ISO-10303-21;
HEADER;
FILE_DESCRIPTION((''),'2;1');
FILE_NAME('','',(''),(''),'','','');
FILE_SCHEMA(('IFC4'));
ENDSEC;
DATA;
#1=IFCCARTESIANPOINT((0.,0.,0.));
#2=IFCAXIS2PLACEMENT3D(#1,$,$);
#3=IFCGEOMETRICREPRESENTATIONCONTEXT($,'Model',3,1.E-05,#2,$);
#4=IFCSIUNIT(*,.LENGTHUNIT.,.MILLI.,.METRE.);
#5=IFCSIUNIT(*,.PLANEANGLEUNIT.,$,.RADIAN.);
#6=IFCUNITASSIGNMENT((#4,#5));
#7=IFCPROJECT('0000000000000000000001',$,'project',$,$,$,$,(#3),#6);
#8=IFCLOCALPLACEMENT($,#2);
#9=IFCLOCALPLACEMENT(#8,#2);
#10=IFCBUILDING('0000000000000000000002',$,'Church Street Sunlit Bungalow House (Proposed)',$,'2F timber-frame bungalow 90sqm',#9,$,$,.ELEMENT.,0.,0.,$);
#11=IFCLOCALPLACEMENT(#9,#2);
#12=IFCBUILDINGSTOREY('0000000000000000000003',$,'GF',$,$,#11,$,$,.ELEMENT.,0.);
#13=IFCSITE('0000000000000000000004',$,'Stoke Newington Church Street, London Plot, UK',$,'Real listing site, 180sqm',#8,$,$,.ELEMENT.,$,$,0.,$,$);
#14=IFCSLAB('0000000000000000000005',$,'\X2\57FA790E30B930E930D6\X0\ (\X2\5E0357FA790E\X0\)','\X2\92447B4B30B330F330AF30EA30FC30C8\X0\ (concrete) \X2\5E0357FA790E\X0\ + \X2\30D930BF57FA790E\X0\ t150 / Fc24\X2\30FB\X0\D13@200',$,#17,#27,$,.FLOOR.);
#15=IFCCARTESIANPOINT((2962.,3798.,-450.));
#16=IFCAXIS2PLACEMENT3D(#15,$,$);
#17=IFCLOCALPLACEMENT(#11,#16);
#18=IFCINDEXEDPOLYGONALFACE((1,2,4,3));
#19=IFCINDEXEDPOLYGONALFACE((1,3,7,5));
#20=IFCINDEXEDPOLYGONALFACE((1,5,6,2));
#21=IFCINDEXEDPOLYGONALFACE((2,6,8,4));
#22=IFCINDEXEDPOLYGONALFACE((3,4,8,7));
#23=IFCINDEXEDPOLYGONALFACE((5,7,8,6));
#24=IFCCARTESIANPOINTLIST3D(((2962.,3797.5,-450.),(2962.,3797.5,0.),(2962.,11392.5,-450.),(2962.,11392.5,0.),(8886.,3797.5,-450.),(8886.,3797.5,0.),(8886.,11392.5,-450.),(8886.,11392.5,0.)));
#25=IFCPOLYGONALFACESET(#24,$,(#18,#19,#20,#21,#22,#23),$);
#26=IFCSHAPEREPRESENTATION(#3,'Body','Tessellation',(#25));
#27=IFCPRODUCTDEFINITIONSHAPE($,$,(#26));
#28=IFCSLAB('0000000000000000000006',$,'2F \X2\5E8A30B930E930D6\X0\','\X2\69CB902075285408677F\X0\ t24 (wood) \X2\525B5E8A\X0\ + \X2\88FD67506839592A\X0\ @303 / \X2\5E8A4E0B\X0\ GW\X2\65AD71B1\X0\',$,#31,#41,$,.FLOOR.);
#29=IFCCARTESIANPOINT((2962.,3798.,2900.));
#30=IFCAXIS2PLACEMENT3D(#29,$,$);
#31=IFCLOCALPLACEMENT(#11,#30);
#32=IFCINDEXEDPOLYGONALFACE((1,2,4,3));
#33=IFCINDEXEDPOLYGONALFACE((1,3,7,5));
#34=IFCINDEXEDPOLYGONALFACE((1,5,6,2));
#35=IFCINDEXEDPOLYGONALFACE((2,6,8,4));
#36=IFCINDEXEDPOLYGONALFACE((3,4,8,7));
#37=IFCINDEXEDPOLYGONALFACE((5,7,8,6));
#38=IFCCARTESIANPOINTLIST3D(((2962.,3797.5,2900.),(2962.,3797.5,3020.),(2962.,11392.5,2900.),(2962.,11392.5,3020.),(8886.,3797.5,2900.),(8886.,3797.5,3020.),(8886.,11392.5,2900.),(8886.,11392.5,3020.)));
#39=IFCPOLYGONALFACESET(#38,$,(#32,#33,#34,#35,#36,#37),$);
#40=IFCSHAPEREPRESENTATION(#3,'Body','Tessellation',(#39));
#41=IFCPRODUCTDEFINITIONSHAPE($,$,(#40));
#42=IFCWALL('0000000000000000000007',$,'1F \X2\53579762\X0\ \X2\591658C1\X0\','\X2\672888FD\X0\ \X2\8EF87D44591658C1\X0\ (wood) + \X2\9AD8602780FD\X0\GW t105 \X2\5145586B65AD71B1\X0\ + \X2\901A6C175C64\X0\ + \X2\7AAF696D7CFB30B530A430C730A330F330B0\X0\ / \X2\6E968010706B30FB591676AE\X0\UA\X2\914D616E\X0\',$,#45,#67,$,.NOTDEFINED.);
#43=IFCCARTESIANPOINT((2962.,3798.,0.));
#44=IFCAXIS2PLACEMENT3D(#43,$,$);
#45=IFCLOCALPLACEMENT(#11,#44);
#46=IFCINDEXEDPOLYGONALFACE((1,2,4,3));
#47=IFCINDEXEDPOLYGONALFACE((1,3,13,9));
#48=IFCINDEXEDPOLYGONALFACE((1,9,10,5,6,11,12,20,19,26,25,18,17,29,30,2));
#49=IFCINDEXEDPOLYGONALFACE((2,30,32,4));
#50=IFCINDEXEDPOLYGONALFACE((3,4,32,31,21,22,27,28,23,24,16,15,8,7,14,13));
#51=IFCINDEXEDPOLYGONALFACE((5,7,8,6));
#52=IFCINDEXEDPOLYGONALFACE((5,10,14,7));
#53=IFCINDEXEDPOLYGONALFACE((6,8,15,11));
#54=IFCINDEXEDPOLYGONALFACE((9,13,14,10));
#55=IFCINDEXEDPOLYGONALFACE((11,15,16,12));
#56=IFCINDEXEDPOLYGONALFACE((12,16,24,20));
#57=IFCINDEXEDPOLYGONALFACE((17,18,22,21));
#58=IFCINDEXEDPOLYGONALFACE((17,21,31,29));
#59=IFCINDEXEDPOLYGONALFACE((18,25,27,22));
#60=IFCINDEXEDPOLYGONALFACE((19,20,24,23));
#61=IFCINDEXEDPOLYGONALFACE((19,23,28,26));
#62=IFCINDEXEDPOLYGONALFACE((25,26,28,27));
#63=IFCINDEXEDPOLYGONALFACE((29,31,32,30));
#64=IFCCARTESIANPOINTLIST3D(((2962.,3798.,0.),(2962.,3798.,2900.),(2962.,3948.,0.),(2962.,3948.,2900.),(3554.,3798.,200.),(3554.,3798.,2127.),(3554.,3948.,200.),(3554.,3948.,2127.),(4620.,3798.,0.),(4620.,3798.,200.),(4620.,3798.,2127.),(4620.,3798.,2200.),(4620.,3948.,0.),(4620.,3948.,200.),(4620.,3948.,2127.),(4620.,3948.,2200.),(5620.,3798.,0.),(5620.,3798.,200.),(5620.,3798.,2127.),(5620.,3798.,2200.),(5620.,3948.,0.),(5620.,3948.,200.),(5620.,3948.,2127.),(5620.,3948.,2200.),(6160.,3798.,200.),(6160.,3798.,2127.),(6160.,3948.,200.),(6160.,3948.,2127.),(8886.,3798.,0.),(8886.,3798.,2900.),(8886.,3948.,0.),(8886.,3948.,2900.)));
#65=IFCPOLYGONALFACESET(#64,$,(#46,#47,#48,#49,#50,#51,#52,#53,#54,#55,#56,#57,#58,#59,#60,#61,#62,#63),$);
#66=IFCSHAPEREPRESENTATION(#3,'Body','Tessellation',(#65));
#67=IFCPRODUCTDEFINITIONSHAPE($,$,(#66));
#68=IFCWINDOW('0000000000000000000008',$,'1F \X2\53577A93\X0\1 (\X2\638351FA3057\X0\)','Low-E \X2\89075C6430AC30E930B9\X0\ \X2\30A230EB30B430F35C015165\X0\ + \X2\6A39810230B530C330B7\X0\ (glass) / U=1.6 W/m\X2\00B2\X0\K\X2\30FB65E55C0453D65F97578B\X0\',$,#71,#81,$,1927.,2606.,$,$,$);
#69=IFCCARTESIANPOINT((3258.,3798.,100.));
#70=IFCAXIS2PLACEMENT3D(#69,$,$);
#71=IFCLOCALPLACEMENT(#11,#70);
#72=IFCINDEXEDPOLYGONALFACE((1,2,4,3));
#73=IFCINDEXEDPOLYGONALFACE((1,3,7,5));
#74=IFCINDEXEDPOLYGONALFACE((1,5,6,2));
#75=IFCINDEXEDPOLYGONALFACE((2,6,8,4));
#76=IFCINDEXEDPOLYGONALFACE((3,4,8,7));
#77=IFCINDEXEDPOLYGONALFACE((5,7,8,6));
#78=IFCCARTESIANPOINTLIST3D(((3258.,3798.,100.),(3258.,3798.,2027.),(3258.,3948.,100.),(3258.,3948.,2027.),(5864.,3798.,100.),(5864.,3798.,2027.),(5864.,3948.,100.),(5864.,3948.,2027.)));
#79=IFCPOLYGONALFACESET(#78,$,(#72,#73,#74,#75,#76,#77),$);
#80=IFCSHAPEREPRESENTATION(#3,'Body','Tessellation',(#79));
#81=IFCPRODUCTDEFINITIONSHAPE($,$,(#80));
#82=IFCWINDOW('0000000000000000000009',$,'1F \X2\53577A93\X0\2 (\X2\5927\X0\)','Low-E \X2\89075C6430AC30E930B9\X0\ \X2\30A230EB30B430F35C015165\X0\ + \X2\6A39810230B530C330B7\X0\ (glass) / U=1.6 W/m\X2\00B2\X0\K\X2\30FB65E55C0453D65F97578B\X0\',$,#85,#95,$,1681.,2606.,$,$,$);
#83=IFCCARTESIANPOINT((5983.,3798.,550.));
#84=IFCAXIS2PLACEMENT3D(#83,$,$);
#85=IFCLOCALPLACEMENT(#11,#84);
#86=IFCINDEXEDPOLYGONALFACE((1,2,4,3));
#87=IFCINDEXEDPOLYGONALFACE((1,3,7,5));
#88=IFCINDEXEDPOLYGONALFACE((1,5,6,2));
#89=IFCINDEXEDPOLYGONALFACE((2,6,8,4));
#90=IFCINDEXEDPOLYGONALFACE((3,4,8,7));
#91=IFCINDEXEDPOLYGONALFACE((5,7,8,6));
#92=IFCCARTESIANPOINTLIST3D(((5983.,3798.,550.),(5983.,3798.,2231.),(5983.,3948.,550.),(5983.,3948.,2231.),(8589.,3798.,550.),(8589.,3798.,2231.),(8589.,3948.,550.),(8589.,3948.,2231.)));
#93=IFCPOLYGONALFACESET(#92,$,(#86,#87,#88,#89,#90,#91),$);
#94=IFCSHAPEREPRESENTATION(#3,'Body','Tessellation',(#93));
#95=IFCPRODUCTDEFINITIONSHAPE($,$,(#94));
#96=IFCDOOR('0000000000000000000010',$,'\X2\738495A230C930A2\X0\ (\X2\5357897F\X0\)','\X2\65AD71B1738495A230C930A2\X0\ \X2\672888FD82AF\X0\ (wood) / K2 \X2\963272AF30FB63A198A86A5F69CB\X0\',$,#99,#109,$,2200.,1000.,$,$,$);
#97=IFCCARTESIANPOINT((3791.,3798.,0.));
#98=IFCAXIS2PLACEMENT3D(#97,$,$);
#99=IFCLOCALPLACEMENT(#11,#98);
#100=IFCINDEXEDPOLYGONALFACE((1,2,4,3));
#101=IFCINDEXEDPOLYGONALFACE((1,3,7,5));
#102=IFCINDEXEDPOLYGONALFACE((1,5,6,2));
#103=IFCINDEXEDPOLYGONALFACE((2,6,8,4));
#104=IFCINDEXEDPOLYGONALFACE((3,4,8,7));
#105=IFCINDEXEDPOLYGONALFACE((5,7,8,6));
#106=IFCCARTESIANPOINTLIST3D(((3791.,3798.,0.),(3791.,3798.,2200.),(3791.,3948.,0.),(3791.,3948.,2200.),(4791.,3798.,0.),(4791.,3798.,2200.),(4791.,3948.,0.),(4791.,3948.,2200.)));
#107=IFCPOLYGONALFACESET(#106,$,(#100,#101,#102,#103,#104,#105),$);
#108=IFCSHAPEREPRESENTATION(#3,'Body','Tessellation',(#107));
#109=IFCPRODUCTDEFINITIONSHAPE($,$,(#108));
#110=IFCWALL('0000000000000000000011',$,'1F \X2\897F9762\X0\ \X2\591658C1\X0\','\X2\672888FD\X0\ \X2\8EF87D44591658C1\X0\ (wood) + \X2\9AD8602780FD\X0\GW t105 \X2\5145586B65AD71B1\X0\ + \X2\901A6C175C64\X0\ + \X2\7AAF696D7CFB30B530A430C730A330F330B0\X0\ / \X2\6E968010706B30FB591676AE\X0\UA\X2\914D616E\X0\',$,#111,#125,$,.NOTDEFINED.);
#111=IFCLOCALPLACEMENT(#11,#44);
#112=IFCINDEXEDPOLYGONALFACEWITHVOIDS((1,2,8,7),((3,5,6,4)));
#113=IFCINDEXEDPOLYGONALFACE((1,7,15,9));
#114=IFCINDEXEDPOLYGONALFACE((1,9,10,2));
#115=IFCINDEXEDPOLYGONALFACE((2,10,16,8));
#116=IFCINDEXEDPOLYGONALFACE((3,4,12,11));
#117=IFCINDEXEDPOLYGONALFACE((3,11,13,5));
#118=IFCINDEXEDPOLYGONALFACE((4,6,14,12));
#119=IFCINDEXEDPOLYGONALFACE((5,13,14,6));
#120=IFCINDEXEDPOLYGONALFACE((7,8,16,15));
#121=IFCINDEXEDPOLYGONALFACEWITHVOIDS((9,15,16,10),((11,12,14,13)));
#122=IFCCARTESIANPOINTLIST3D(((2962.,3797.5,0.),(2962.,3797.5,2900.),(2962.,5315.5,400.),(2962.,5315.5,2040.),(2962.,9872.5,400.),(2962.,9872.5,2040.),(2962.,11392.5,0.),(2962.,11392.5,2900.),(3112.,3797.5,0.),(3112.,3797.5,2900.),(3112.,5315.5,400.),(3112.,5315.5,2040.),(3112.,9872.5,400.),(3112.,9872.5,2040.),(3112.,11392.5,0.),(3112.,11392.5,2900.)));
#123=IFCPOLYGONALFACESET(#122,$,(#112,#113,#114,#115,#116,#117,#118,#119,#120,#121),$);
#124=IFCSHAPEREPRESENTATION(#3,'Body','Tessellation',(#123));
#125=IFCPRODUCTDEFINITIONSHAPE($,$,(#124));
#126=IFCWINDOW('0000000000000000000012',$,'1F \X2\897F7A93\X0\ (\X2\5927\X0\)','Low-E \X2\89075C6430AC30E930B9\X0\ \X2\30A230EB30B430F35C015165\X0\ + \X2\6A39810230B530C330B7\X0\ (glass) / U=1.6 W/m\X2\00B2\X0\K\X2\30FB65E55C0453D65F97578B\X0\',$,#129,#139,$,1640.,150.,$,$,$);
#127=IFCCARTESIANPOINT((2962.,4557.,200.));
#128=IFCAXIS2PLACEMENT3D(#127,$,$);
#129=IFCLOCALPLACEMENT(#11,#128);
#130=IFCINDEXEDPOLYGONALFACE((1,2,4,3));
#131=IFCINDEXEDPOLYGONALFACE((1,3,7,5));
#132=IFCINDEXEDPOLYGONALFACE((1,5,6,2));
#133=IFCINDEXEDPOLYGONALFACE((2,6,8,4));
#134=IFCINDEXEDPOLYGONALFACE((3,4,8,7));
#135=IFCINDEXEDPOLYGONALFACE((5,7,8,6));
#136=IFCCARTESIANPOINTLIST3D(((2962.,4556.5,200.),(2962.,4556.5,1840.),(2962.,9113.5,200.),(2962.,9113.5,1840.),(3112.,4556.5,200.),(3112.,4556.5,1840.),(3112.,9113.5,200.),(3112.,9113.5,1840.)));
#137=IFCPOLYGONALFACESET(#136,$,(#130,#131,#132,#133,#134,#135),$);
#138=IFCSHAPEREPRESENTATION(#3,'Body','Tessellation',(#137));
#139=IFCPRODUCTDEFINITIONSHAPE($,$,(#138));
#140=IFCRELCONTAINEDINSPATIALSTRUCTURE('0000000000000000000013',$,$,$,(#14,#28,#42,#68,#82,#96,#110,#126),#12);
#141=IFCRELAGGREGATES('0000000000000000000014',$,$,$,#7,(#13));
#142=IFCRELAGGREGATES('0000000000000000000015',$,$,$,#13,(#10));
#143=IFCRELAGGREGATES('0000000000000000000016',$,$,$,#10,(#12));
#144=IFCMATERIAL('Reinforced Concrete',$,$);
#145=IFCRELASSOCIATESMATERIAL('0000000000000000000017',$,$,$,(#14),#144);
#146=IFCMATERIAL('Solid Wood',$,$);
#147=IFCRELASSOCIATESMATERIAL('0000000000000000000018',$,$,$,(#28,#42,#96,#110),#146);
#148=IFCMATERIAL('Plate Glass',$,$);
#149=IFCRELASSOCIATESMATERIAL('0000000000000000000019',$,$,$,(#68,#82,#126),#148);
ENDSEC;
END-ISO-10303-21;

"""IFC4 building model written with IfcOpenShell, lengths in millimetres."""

from ifc_helpers import new_model, si_unit, frame, frame_2d, origin, place, context, project, spatial, rectangle, extrude, material, element, fill, save


model = new_model("IFC4")

# Units and contexts
model_context = context("Model", 3, precision=1e-05, world=origin())
ifc_project = project(units=[si_unit("LENGTHUNIT", "METRE", prefix="MILLI"), si_unit("PLANEANGLEUNIT", "RADIAN")], contexts=[model_context])

# Site, building, storey
site_placement = place(None, origin())
site = spatial("IfcSite", under=ifc_project, at=site_placement, Name="Stoke Newington Church Street, London Plot, UK", ObjectType="Real listing site, 180sqm", CompositionType="ELEMENT", RefElevation=0.0)
building_placement = place(site_placement, origin())
building = spatial("IfcBuilding", under=site, at=building_placement, Name="Church Street Sunlit Bungalow House (Proposed)", ObjectType="2F timber-frame bungalow 90sqm", CompositionType="ELEMENT", ElevationOfRefHeight=0.0, ElevationOfTerrain=0.0)
storey_placement = place(building_placement, origin())
storey = spatial("IfcBuildingStorey", under=building, at=storey_placement, Name="GF", CompositionType="ELEMENT", Elevation=0.0)

# Slabs
ifc_material_1 = material(Name="Reinforced Concrete")
slab_1_placement = place(storey_placement, frame((2962.0, 3798.0, -450.0)))
element("IfcSlab", 1, at=slab_1_placement, inside=storey, material=ifc_material_1, Name="基礎スラブ (布基礎)", Description="鉄筋コンクリート (concrete) 布基礎 + ベタ基礎 t150 / Fc24・D13@200", PredefinedType="FLOOR", context=model_context, shape_type="SweptSolid", body=[
    extrude(rectangle(XDim=5924.0, YDim=7595.0, at=frame_2d((2962.0, 3797.0))), frame((2962.0, 3798.0, -450.0)), (0.0, 0.0, 1.0), 450.0),
])
ifc_material_2 = material(Name="Solid Wood")
slab_2_placement = place(storey_placement, frame((2962.0, 3798.0, 2900.0)))
element("IfcSlab", 2, at=slab_2_placement, inside=storey, material=ifc_material_2, Name="2F 床スラブ", Description="構造用合板 t24 (wood) 剛床 + 製材根太 @303 / 床下 GW断熱", PredefinedType="FLOOR", context=model_context, shape_type="SweptSolid", body=[
    extrude(rectangle(XDim=5924.0, YDim=7595.0, at=frame_2d((2962.0, 3797.0))), frame((2962.0, 3798.0, 2900.0)), (0.0, 0.0, 1.0), 120.0),
])

# Wall, openings, windows, door
wall_1_placement = place(storey_placement, frame((2962.0, 3798.0, 0.0)))
wall_1 = element("IfcWall", 3, at=wall_1_placement, inside=storey, material=ifc_material_2, Name="1F 南面 外壁", Description="木製 軸組外壁 (wood) + 高性能GW t105 充填断熱 + 通気層 + 窯業系サイディング / 準耐火・外皮UA配慮", PredefinedType="NOTDEFINED", context=model_context, shape_type="SweptSolid", body=[
    extrude(rectangle(XDim=5924.0, YDim=150.0, at=frame_2d((2962.0, 75.0))), frame((2962.0, 3798.0, 0.0)), (0.0, 0.0, 1.0), 2900.0),
])
opening_1_placement = place(storey_placement, frame((3258.0, 3798.0, 100.0)))
opening_1 = element("IfcOpeningElement", 4, at=opening_1_placement, cuts=wall_1, PredefinedType="NOTDEFINED", context=model_context, shape_type="SweptSolid", body=[
    extrude(rectangle(XDim=2606.0, YDim=150.0, at=frame_2d((1303.0, 75.0))), frame((3258.0, 3798.0, 100.0)), (0.0, 0.0, 1.0), 1927.0),
])
opening_2_placement = place(storey_placement, frame((5983.0, 3798.0, 550.0)))
opening_2 = element("IfcOpeningElement", 5, at=opening_2_placement, cuts=wall_1, PredefinedType="NOTDEFINED", context=model_context, shape_type="SweptSolid", body=[
    extrude(rectangle(XDim=2606.0, YDim=150.0, at=frame_2d((1303.0, 75.0))), frame((5983.0, 3798.0, 550.0)), (0.0, 0.0, 1.0), 1681.0),
])
opening_3_placement = place(storey_placement, frame((3791.0, 3798.0, 0.0)))
opening_3 = element("IfcOpeningElement", 6, at=opening_3_placement, cuts=wall_1, PredefinedType="NOTDEFINED", context=model_context, shape_type="SweptSolid", body=[
    extrude(rectangle(XDim=1000.0, YDim=150.0, at=frame_2d((500.0, 75.0))), frame((3791.0, 3798.0, 0.0)), (0.0, 0.0, 1.0), 2200.0),
])
ifc_material_3 = material(Name="Plate Glass")
window_1_placement = place(storey_placement, frame((3258.0, 3798.0, 100.0)))
window_1 = element("IfcWindow", 7, at=window_1_placement, inside=storey, material=ifc_material_3, Name="1F 南窓1 (掃出し)", Description="Low-E 複層ガラス アルゴン封入 + 樹脂サッシ (glass) / U=1.6 W/m²K・日射取得型", OverallHeight=1927.0, OverallWidth=2606.0, context=model_context, shape_type="SweptSolid", body=[
    extrude(rectangle(XDim=2606.0, YDim=150.0, at=frame_2d((1303.0, 75.0))), frame((3258.0, 3798.0, 100.0)), (0.0, 0.0, 1.0), 1927.0),
])
fill(opening_1, window_1)
window_2_placement = place(storey_placement, frame((5983.0, 3798.0, 550.0)))
window_2 = element("IfcWindow", 8, at=window_2_placement, inside=storey, material=ifc_material_3, Name="1F 南窓2 (大)", Description="Low-E 複層ガラス アルゴン封入 + 樹脂サッシ (glass) / U=1.6 W/m²K・日射取得型", OverallHeight=1681.0, OverallWidth=2606.0, context=model_context, shape_type="SweptSolid", body=[
    extrude(rectangle(XDim=2606.0, YDim=150.0, at=frame_2d((1303.0, 75.0))), frame((5983.0, 3798.0, 550.0)), (0.0, 0.0, 1.0), 1681.0),
])
fill(opening_2, window_2)
door_placement = place(storey_placement, frame((3791.0, 3798.0, 0.0)))
door = element("IfcDoor", 9, at=door_placement, inside=storey, material=ifc_material_2, Name="玄関ドア (南西)", Description="断熱玄関ドア 木製芯 (wood) / K2 防犯・採風機構", OverallHeight=2200.0, OverallWidth=1000.0, context=model_context, shape_type="SweptSolid", body=[
    extrude(rectangle(XDim=1000.0, YDim=150.0, at=frame_2d((500.0, 75.0))), frame((3791.0, 3798.0, 0.0)), (0.0, 0.0, 1.0), 2200.0),
])
fill(opening_3, door)

# Wall, opening, window
wall_2_placement = place(storey_placement, frame((2962.0, 3798.0, 0.0)))
wall_2 = element("IfcWall", 10, at=wall_2_placement, inside=storey, material=ifc_material_2, Name="1F 西面 外壁", Description="木製 軸組外壁 (wood) + 高性能GW t105 充填断熱 + 通気層 + 窯業系サイディング / 準耐火・外皮UA配慮", PredefinedType="NOTDEFINED", context=model_context, shape_type="SweptSolid", body=[
    extrude(rectangle(XDim=150.0, YDim=7595.0, at=frame_2d((75.0, 3797.0))), frame((2962.0, 3798.0, 0.0)), (0.0, 0.0, 1.0), 2900.0),
])
opening_4_placement = place(storey_placement, frame((2962.0, 4557.0, 200.0)))
opening_4 = element("IfcOpeningElement", 11, at=opening_4_placement, cuts=wall_2, PredefinedType="NOTDEFINED", context=model_context, shape_type="SweptSolid", body=[
    extrude(rectangle(XDim=150.0, YDim=4557.0, at=frame_2d((75.0, 2278.0))), frame((2962.0, 4557.0, 200.0)), (0.0, 0.0, 1.0), 1640.0),
])
window_3_placement = place(storey_placement, frame((2962.0, 4557.0, 200.0)))
window_3 = element("IfcWindow", 12, at=window_3_placement, inside=storey, material=ifc_material_3, Name="1F 西窓 (大)", Description="Low-E 複層ガラス アルゴン封入 + 樹脂サッシ (glass) / U=1.6 W/m²K・日射取得型", OverallHeight=1640.0, OverallWidth=150.0, context=model_context, shape_type="SweptSolid", body=[
    extrude(rectangle(XDim=150.0, YDim=4557.0, at=frame_2d((75.0, 2278.0))), frame((2962.0, 4557.0, 200.0)), (0.0, 0.0, 1.0), 1640.0),
])
fill(opening_4, window_3)

save(model, "model.ifc")
